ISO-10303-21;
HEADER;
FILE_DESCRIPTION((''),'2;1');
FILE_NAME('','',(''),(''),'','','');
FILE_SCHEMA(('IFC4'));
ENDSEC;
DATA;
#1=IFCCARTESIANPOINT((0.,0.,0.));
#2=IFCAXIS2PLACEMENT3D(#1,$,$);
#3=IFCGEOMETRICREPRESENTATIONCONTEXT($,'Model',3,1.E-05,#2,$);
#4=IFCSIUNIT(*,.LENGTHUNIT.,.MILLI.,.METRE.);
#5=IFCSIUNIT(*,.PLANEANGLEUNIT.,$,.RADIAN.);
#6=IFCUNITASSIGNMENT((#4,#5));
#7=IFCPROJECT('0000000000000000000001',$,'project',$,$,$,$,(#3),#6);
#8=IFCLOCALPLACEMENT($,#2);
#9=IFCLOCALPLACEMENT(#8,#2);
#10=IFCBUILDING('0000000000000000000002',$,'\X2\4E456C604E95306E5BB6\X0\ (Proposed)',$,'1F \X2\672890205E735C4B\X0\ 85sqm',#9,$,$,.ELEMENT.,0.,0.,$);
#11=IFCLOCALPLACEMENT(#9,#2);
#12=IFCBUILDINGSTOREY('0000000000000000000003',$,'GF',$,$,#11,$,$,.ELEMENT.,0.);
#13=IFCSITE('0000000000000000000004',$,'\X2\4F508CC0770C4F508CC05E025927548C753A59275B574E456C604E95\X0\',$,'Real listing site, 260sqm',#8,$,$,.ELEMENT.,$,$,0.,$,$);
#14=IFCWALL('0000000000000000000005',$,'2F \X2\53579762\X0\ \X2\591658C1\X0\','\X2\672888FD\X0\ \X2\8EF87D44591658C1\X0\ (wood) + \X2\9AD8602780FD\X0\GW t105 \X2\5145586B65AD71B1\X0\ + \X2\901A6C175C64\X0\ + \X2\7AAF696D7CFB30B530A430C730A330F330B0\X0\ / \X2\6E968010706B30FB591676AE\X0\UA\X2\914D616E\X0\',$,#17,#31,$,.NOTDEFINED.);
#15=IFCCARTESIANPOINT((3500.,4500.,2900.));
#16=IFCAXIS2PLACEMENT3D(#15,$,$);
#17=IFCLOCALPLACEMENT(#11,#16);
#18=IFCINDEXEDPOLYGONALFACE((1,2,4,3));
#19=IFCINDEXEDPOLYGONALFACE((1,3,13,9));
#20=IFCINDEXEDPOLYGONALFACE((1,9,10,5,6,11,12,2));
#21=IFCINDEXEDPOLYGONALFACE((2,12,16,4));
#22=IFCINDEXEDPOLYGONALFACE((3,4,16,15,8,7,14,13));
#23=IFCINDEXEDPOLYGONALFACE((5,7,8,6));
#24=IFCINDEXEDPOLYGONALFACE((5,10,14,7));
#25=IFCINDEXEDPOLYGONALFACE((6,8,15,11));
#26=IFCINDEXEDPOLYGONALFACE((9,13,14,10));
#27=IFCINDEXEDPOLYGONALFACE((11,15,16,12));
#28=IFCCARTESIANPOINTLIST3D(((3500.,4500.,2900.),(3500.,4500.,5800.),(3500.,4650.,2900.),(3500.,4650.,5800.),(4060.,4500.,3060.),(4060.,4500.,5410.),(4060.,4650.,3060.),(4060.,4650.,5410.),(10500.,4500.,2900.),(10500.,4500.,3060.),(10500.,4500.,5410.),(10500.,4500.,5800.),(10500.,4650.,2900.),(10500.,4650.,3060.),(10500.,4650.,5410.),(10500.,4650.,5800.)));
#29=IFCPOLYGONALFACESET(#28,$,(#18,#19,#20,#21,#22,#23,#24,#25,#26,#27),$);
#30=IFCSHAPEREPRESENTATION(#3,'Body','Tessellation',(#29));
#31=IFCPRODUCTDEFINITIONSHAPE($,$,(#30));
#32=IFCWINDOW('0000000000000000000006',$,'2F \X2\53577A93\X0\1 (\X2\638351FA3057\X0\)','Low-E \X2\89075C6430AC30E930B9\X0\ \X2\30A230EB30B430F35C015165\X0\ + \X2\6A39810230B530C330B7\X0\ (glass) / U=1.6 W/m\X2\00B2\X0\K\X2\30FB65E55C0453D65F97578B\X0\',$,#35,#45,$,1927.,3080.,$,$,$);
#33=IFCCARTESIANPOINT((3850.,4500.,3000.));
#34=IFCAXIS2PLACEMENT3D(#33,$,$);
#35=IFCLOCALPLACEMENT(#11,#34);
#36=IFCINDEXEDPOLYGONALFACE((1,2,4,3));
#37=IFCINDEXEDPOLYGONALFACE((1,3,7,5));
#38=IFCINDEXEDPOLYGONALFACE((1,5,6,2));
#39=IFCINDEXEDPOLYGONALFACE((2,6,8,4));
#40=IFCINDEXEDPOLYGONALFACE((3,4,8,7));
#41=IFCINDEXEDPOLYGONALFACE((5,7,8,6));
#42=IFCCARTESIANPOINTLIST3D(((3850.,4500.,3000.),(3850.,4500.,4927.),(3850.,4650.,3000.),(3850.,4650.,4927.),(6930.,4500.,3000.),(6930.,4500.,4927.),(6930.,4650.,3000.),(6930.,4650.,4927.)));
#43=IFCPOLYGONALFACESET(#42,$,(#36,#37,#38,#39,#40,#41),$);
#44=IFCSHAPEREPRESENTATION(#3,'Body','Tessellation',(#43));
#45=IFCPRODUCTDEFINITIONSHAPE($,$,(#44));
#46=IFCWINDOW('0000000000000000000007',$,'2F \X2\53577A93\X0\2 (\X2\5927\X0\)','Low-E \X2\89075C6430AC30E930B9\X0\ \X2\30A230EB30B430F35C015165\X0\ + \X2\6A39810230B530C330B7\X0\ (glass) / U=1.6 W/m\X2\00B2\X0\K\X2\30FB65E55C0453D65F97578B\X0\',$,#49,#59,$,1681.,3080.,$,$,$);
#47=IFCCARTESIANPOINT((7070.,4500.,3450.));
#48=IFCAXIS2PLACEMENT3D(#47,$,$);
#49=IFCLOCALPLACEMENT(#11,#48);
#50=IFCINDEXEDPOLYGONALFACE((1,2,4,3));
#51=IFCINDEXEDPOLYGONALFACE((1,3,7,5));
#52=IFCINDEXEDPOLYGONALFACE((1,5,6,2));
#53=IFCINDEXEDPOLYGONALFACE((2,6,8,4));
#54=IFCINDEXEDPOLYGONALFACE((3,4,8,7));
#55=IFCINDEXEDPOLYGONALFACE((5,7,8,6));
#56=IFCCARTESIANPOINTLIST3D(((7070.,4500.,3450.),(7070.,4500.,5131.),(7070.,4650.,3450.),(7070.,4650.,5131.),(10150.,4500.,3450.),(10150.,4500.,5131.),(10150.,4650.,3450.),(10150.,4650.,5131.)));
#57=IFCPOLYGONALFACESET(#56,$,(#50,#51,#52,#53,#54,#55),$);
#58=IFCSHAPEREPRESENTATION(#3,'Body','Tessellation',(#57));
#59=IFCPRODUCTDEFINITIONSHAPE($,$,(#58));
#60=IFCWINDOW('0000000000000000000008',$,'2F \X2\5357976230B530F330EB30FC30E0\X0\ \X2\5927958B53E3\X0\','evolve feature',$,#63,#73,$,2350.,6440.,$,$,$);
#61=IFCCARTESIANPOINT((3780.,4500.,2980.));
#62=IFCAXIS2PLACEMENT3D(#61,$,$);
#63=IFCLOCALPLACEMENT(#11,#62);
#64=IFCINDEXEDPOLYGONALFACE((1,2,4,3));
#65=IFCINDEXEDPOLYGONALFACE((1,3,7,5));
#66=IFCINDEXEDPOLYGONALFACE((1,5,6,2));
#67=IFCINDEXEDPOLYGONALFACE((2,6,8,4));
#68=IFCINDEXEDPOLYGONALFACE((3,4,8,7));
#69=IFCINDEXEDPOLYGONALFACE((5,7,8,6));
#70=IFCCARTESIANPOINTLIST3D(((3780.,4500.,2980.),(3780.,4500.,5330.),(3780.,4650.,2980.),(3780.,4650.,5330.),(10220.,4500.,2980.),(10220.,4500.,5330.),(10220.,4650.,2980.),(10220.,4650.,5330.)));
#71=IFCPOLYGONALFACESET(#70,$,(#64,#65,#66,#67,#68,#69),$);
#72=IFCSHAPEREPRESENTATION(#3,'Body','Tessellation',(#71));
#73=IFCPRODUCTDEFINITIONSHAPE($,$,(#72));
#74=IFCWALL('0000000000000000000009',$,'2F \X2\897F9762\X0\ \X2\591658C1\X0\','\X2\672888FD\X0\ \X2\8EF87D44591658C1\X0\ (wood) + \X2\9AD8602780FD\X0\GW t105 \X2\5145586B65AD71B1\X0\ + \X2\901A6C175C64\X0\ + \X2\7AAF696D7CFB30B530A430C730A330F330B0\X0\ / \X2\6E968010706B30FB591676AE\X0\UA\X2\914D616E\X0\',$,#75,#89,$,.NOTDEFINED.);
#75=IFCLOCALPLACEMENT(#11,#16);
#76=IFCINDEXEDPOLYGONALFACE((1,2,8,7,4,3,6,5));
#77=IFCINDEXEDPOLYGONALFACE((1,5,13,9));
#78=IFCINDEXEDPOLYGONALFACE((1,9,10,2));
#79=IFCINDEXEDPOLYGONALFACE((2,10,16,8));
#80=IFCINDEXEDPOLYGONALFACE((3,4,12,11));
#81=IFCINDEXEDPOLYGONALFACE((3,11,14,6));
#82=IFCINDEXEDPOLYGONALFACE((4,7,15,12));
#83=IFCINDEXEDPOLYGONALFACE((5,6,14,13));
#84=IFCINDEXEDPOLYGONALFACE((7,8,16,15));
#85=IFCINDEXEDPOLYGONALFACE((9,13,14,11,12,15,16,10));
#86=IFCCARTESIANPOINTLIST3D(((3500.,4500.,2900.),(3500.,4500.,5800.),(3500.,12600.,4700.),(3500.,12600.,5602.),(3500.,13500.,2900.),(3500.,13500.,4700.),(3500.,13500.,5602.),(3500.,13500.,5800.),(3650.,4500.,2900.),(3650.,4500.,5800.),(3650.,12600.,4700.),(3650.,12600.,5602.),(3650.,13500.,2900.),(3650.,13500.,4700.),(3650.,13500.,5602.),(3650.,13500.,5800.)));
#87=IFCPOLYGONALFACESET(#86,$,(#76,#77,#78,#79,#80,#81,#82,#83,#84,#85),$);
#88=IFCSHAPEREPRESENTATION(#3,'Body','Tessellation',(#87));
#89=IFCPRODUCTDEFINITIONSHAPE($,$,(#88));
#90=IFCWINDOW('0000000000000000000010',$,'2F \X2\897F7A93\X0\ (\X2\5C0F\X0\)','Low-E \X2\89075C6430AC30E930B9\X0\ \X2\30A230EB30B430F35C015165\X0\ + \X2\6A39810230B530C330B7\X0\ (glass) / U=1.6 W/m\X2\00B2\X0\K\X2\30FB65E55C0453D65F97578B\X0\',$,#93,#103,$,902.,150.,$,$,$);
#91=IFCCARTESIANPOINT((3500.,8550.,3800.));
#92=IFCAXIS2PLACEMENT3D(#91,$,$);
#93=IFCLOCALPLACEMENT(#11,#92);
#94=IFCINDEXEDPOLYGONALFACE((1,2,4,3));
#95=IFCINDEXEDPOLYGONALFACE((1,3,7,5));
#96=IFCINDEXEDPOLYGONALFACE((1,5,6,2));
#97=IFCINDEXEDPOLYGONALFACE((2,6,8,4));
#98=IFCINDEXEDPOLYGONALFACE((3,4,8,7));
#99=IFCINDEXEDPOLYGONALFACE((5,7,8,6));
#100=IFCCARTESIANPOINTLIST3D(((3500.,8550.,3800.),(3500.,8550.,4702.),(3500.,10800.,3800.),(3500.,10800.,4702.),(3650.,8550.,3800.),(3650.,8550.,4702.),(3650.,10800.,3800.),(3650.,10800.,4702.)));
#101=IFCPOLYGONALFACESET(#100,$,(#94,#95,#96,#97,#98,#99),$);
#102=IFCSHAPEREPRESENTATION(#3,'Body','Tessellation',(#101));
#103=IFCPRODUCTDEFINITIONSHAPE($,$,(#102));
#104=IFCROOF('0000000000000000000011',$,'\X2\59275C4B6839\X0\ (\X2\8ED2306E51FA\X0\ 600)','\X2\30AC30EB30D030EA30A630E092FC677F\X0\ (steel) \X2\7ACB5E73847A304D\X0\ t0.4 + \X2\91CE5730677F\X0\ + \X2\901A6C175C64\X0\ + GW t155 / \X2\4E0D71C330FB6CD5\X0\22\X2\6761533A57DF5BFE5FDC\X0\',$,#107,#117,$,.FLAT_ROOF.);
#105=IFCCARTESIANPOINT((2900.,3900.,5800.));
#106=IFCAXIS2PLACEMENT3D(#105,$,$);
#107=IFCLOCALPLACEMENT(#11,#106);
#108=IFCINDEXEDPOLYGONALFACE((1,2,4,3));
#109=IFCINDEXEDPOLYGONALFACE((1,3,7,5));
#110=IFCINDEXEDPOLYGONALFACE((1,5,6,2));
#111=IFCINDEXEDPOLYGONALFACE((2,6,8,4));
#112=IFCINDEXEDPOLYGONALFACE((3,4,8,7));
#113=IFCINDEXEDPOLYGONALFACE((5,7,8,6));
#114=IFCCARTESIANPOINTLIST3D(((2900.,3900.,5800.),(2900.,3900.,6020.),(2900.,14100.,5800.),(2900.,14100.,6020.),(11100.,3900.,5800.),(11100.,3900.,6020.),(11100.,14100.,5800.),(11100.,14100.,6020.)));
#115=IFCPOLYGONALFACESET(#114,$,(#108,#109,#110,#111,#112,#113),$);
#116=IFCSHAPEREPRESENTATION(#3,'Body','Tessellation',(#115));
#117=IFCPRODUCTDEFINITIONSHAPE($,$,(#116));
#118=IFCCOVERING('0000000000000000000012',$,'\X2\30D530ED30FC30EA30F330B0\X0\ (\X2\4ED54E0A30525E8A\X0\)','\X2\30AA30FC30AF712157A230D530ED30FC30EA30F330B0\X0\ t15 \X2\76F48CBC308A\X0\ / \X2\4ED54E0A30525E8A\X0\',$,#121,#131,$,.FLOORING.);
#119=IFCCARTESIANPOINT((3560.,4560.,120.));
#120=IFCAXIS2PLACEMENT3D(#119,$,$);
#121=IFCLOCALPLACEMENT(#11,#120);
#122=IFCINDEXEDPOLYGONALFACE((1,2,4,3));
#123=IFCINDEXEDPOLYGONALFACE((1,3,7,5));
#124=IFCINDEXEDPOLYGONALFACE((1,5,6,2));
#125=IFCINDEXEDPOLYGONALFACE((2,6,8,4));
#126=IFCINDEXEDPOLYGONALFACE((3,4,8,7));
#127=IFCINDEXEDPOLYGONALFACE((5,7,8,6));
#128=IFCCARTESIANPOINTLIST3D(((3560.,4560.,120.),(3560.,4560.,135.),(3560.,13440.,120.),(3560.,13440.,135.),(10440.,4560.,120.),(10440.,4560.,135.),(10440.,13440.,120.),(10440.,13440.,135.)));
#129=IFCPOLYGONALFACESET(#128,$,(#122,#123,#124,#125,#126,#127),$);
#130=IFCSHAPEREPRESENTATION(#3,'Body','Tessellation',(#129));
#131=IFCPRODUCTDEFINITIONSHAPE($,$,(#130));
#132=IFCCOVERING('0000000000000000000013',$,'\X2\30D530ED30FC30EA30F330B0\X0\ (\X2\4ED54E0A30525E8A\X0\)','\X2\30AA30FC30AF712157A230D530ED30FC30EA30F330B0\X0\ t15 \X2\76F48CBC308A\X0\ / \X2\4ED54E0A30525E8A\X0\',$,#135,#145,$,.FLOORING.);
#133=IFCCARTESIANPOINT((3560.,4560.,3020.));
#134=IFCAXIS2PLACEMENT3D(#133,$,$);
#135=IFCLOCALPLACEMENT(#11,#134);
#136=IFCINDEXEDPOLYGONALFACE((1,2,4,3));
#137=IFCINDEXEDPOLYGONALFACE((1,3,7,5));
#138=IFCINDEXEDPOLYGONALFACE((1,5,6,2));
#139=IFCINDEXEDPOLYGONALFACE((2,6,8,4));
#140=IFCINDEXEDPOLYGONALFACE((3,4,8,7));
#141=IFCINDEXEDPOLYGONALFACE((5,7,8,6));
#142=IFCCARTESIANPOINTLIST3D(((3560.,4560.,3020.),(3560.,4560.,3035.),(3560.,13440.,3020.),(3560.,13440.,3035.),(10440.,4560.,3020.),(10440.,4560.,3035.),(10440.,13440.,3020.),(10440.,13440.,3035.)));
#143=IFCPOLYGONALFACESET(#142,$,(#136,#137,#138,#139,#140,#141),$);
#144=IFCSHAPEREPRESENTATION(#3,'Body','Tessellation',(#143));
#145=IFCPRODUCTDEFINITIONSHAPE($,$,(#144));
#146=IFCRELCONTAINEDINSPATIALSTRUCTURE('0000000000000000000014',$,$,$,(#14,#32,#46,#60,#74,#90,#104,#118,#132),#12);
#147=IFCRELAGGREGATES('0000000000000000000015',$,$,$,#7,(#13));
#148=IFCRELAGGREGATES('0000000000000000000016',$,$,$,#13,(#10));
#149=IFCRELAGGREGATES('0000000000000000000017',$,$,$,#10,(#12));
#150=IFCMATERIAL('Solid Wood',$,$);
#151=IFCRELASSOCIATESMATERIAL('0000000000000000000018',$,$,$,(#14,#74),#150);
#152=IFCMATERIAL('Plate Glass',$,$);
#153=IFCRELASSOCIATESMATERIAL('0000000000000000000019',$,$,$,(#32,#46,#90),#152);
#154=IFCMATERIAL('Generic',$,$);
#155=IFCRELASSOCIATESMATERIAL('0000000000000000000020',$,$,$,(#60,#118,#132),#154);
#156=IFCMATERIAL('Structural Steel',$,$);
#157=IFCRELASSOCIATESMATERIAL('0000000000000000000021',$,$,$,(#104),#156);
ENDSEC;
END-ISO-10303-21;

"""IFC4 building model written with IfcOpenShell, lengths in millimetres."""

from ifc_helpers import new_model, si_unit, frame, frame_2d, origin, place, context, project, spatial, rectangle, extrude, material, element, fill, save


model = new_model("IFC4")

# Units and contexts
model_context = context("Model", 3, precision=1e-05, world=origin())
ifc_project = project(units=[si_unit("LENGTHUNIT", "METRE", prefix="MILLI"), si_unit("PLANEANGLEUNIT", "RADIAN")], contexts=[model_context])

# Site, building, storey
site_placement = place(None, origin())
site = spatial("IfcSite", under=ifc_project, at=site_placement, Name="佐賀県佐賀市大和町大字久池井", ObjectType="Real listing site, 260sqm", CompositionType="ELEMENT", RefElevation=0.0)
building_placement = place(site_placement, origin())
building = spatial("IfcBuilding", under=site, at=building_placement, Name="久池井の家 (Proposed)", ObjectType="1F 木造平屋 85sqm", CompositionType="ELEMENT", ElevationOfRefHeight=0.0, ElevationOfTerrain=0.0)
storey_placement = place(building_placement, origin())
storey = spatial("IfcBuildingStorey", under=building, at=storey_placement, Name="GF", CompositionType="ELEMENT", Elevation=0.0)

# Shared definitions
ifc_material_1 = material(Name="Solid Wood")
ifc_material_2 = material(Name="Generic")

# Shared definitions
ifc_material_3 = material(Name="Plate Glass")

# Wall, openings, windows
wall_1_placement = place(storey_placement, frame((3500.0, 4500.0, 2900.0)))
wall_1 = element("IfcWall", 1, at=wall_1_placement, inside=storey, material=ifc_material_1, Name="2F 南面 外壁", Description="木製 軸組外壁 (wood) + 高性能GW t105 充填断熱 + 通気層 + 窯業系サイディング / 準耐火・外皮UA配慮", PredefinedType="NOTDEFINED", context=model_context, shape_type="SweptSolid", body=[
    extrude(rectangle(XDim=7000.0, YDim=150.0, at=frame_2d((3500.0, 75.0))), frame((3500.0, 4500.0, 2900.0)), (0.0, 0.0, 1.0), 2900.0),
])
opening_1_placement = place(storey_placement, frame((3850.0, 4500.0, 3000.0)))
opening_1 = element("IfcOpeningElement", 2, at=opening_1_placement, cuts=wall_1, PredefinedType="NOTDEFINED", context=model_context, shape_type="SweptSolid", body=[
    extrude(rectangle(XDim=3080.0, YDim=150.0, at=frame_2d((1540.0, 75.0))), frame((3850.0, 4500.0, 3000.0)), (0.0, 0.0, 1.0), 1927.0),
])
opening_2_placement = place(storey_placement, frame((7070.0, 4500.0, 3450.0)))
opening_2 = element("IfcOpeningElement", 3, at=opening_2_placement, cuts=wall_1, PredefinedType="NOTDEFINED", context=model_context, shape_type="SweptSolid", body=[
    extrude(rectangle(XDim=3080.0, YDim=150.0, at=frame_2d((1540.0, 75.0))), frame((7070.0, 4500.0, 3450.0)), (0.0, 0.0, 1.0), 1681.0),
])
opening_3_placement = place(storey_placement, frame((3780.0, 4500.0, 2980.0)))
opening_3 = element("IfcOpeningElement", 4, at=opening_3_placement, cuts=wall_1, PredefinedType="NOTDEFINED", context=model_context, shape_type="SweptSolid", body=[
    extrude(rectangle(XDim=6440.0, YDim=150.0, at=frame_2d((3220.0, 75.0))), frame((3780.0, 4500.0, 2980.0)), (0.0, 0.0, 1.0), 2350.0),
])
window_1_placement = place(storey_placement, frame((3850.0, 4500.0, 3000.0)))
window_1 = element("IfcWindow", 5, at=window_1_placement, inside=storey, material=ifc_material_3, Name="2F 南窓1 (掃出し)", Description="Low-E 複層ガラス アルゴン封入 + 樹脂サッシ (glass) / U=1.6 W/m²K・日射取得型", OverallHeight=1927.0, OverallWidth=3080.0, context=model_context, shape_type="SweptSolid", body=[
    extrude(rectangle(XDim=3080.0, YDim=150.0, at=frame_2d((1540.0, 75.0))), frame((3850.0, 4500.0, 3000.0)), (0.0, 0.0, 1.0), 1927.0),
])
fill(opening_1, window_1)
window_2_placement = place(storey_placement, frame((7070.0, 4500.0, 3450.0)))
window_2 = element("IfcWindow", 6, at=window_2_placement, inside=storey, material=ifc_material_3, Name="2F 南窓2 (大)", Description="Low-E 複層ガラス アルゴン封入 + 樹脂サッシ (glass) / U=1.6 W/m²K・日射取得型", OverallHeight=1681.0, OverallWidth=3080.0, context=model_context, shape_type="SweptSolid", body=[
    extrude(rectangle(XDim=3080.0, YDim=150.0, at=frame_2d((1540.0, 75.0))), frame((7070.0, 4500.0, 3450.0)), (0.0, 0.0, 1.0), 1681.0),
])
fill(opening_2, window_2)
window_3_placement = place(storey_placement, frame((3780.0, 4500.0, 2980.0)))
window_3 = element("IfcWindow", 7, at=window_3_placement, inside=storey, material=ifc_material_2, Name="2F 南面サンルーム 大開口", Description="evolve feature", OverallHeight=2350.0, OverallWidth=6440.0, context=model_context, shape_type="SweptSolid", body=[
    extrude(rectangle(XDim=6440.0, YDim=150.0, at=frame_2d((3220.0, 75.0))), frame((3780.0, 4500.0, 2980.0)), (0.0, 0.0, 1.0), 2350.0),
])
fill(opening_3, window_3)

# Wall, opening, window
wall_2_placement = place(storey_placement, frame((3500.0, 4500.0, 2900.0)))
wall_2 = element("IfcWall", 8, at=wall_2_placement, inside=storey, material=ifc_material_1, Name="2F 西面 外壁", Description="木製 軸組外壁 (wood) + 高性能GW t105 充填断熱 + 通気層 + 窯業系サイディング / 準耐火・外皮UA配慮", PredefinedType="NOTDEFINED", context=model_context, shape_type="SweptSolid", body=[
    extrude(rectangle(XDim=150.0, YDim=9000.0, at=frame_2d((75.0, 4500.0))), frame((3500.0, 4500.0, 2900.0)), (0.0, 0.0, 1.0), 2900.0),
])
opening_4_placement = place(storey_placement, frame((3500.0, 8550.0, 3800.0)))
opening_4 = element("IfcOpeningElement", 9, at=opening_4_placement, cuts=wall_2, PredefinedType="NOTDEFINED", context=model_context, shape_type="SweptSolid", body=[
    extrude(rectangle(XDim=150.0, YDim=2250.0, at=frame_2d((75.0, 1125.0))), frame((3500.0, 8550.0, 3800.0)), (0.0, 0.0, 1.0), 902.0),
])
window_4_placement = place(storey_placement, frame((3500.0, 8550.0, 3800.0)))
window_4 = element("IfcWindow", 10, at=window_4_placement, inside=storey, material=ifc_material_3, Name="2F 西窓 (小)", Description="Low-E 複層ガラス アルゴン封入 + 樹脂サッシ (glass) / U=1.6 W/m²K・日射取得型", OverallHeight=902.0, OverallWidth=150.0, context=model_context, shape_type="SweptSolid", body=[
    extrude(rectangle(XDim=150.0, YDim=2250.0, at=frame_2d((75.0, 1125.0))), frame((3500.0, 8550.0, 3800.0)), (0.0, 0.0, 1.0), 902.0),
])
fill(opening_4, window_4)

# Roof
ifc_material_4 = material(Name="Structural Steel")
roof_placement = place(storey_placement, frame((2900.0, 3900.0, 5800.0)))
element("IfcRoof", 11, at=roof_placement, inside=storey, material=ifc_material_4, Name="大屋根 (軒の出 600)", Description="ガルバリウム鋼板 (steel) 立平葺き t0.4 + 野地板 + 通気層 + GW t155 / 不燃・法22条区域対応", PredefinedType="FLAT_ROOF", context=model_context, shape_type="SweptSolid", body=[
    extrude(rectangle(XDim=8200.0, YDim=10200.0, at=frame_2d((4100.0, 5100.0))), frame((2900.0, 3900.0, 5800.0)), (0.0, 0.0, 1.0), 220.0),
])

# Coverings
covering_1_placement = place(storey_placement, frame((3560.0, 4560.0, 120.0)))
element("IfcCovering", 12, at=covering_1_placement, inside=storey, material=ifc_material_2, Name="フローリング (仕上げ床)", Description="オーク無垢フローリング t15 直貼り / 仕上げ床", PredefinedType="FLOORING", context=model_context, shape_type="SweptSolid", body=[
    extrude(rectangle(XDim=6880.0, YDim=8880.0, at=frame_2d((3440.0, 4440.0))), frame((3560.0, 4560.0, 120.0)), (0.0, 0.0, 1.0), 15.0),
])
covering_2_placement = place(storey_placement, frame((3560.0, 4560.0, 3020.0)))
element("IfcCovering", 13, at=covering_2_placement, inside=storey, material=ifc_material_2, Name="フローリング (仕上げ床)", Description="オーク無垢フローリング t15 直貼り / 仕上げ床", PredefinedType="FLOORING", context=model_context, shape_type="SweptSolid", body=[
    extrude(rectangle(XDim=6880.0, YDim=8880.0, at=frame_2d((3440.0, 4440.0))), frame((3560.0, 4560.0, 3020.0)), (0.0, 0.0, 1.0), 15.0),
])

save(model, "model.ifc")
